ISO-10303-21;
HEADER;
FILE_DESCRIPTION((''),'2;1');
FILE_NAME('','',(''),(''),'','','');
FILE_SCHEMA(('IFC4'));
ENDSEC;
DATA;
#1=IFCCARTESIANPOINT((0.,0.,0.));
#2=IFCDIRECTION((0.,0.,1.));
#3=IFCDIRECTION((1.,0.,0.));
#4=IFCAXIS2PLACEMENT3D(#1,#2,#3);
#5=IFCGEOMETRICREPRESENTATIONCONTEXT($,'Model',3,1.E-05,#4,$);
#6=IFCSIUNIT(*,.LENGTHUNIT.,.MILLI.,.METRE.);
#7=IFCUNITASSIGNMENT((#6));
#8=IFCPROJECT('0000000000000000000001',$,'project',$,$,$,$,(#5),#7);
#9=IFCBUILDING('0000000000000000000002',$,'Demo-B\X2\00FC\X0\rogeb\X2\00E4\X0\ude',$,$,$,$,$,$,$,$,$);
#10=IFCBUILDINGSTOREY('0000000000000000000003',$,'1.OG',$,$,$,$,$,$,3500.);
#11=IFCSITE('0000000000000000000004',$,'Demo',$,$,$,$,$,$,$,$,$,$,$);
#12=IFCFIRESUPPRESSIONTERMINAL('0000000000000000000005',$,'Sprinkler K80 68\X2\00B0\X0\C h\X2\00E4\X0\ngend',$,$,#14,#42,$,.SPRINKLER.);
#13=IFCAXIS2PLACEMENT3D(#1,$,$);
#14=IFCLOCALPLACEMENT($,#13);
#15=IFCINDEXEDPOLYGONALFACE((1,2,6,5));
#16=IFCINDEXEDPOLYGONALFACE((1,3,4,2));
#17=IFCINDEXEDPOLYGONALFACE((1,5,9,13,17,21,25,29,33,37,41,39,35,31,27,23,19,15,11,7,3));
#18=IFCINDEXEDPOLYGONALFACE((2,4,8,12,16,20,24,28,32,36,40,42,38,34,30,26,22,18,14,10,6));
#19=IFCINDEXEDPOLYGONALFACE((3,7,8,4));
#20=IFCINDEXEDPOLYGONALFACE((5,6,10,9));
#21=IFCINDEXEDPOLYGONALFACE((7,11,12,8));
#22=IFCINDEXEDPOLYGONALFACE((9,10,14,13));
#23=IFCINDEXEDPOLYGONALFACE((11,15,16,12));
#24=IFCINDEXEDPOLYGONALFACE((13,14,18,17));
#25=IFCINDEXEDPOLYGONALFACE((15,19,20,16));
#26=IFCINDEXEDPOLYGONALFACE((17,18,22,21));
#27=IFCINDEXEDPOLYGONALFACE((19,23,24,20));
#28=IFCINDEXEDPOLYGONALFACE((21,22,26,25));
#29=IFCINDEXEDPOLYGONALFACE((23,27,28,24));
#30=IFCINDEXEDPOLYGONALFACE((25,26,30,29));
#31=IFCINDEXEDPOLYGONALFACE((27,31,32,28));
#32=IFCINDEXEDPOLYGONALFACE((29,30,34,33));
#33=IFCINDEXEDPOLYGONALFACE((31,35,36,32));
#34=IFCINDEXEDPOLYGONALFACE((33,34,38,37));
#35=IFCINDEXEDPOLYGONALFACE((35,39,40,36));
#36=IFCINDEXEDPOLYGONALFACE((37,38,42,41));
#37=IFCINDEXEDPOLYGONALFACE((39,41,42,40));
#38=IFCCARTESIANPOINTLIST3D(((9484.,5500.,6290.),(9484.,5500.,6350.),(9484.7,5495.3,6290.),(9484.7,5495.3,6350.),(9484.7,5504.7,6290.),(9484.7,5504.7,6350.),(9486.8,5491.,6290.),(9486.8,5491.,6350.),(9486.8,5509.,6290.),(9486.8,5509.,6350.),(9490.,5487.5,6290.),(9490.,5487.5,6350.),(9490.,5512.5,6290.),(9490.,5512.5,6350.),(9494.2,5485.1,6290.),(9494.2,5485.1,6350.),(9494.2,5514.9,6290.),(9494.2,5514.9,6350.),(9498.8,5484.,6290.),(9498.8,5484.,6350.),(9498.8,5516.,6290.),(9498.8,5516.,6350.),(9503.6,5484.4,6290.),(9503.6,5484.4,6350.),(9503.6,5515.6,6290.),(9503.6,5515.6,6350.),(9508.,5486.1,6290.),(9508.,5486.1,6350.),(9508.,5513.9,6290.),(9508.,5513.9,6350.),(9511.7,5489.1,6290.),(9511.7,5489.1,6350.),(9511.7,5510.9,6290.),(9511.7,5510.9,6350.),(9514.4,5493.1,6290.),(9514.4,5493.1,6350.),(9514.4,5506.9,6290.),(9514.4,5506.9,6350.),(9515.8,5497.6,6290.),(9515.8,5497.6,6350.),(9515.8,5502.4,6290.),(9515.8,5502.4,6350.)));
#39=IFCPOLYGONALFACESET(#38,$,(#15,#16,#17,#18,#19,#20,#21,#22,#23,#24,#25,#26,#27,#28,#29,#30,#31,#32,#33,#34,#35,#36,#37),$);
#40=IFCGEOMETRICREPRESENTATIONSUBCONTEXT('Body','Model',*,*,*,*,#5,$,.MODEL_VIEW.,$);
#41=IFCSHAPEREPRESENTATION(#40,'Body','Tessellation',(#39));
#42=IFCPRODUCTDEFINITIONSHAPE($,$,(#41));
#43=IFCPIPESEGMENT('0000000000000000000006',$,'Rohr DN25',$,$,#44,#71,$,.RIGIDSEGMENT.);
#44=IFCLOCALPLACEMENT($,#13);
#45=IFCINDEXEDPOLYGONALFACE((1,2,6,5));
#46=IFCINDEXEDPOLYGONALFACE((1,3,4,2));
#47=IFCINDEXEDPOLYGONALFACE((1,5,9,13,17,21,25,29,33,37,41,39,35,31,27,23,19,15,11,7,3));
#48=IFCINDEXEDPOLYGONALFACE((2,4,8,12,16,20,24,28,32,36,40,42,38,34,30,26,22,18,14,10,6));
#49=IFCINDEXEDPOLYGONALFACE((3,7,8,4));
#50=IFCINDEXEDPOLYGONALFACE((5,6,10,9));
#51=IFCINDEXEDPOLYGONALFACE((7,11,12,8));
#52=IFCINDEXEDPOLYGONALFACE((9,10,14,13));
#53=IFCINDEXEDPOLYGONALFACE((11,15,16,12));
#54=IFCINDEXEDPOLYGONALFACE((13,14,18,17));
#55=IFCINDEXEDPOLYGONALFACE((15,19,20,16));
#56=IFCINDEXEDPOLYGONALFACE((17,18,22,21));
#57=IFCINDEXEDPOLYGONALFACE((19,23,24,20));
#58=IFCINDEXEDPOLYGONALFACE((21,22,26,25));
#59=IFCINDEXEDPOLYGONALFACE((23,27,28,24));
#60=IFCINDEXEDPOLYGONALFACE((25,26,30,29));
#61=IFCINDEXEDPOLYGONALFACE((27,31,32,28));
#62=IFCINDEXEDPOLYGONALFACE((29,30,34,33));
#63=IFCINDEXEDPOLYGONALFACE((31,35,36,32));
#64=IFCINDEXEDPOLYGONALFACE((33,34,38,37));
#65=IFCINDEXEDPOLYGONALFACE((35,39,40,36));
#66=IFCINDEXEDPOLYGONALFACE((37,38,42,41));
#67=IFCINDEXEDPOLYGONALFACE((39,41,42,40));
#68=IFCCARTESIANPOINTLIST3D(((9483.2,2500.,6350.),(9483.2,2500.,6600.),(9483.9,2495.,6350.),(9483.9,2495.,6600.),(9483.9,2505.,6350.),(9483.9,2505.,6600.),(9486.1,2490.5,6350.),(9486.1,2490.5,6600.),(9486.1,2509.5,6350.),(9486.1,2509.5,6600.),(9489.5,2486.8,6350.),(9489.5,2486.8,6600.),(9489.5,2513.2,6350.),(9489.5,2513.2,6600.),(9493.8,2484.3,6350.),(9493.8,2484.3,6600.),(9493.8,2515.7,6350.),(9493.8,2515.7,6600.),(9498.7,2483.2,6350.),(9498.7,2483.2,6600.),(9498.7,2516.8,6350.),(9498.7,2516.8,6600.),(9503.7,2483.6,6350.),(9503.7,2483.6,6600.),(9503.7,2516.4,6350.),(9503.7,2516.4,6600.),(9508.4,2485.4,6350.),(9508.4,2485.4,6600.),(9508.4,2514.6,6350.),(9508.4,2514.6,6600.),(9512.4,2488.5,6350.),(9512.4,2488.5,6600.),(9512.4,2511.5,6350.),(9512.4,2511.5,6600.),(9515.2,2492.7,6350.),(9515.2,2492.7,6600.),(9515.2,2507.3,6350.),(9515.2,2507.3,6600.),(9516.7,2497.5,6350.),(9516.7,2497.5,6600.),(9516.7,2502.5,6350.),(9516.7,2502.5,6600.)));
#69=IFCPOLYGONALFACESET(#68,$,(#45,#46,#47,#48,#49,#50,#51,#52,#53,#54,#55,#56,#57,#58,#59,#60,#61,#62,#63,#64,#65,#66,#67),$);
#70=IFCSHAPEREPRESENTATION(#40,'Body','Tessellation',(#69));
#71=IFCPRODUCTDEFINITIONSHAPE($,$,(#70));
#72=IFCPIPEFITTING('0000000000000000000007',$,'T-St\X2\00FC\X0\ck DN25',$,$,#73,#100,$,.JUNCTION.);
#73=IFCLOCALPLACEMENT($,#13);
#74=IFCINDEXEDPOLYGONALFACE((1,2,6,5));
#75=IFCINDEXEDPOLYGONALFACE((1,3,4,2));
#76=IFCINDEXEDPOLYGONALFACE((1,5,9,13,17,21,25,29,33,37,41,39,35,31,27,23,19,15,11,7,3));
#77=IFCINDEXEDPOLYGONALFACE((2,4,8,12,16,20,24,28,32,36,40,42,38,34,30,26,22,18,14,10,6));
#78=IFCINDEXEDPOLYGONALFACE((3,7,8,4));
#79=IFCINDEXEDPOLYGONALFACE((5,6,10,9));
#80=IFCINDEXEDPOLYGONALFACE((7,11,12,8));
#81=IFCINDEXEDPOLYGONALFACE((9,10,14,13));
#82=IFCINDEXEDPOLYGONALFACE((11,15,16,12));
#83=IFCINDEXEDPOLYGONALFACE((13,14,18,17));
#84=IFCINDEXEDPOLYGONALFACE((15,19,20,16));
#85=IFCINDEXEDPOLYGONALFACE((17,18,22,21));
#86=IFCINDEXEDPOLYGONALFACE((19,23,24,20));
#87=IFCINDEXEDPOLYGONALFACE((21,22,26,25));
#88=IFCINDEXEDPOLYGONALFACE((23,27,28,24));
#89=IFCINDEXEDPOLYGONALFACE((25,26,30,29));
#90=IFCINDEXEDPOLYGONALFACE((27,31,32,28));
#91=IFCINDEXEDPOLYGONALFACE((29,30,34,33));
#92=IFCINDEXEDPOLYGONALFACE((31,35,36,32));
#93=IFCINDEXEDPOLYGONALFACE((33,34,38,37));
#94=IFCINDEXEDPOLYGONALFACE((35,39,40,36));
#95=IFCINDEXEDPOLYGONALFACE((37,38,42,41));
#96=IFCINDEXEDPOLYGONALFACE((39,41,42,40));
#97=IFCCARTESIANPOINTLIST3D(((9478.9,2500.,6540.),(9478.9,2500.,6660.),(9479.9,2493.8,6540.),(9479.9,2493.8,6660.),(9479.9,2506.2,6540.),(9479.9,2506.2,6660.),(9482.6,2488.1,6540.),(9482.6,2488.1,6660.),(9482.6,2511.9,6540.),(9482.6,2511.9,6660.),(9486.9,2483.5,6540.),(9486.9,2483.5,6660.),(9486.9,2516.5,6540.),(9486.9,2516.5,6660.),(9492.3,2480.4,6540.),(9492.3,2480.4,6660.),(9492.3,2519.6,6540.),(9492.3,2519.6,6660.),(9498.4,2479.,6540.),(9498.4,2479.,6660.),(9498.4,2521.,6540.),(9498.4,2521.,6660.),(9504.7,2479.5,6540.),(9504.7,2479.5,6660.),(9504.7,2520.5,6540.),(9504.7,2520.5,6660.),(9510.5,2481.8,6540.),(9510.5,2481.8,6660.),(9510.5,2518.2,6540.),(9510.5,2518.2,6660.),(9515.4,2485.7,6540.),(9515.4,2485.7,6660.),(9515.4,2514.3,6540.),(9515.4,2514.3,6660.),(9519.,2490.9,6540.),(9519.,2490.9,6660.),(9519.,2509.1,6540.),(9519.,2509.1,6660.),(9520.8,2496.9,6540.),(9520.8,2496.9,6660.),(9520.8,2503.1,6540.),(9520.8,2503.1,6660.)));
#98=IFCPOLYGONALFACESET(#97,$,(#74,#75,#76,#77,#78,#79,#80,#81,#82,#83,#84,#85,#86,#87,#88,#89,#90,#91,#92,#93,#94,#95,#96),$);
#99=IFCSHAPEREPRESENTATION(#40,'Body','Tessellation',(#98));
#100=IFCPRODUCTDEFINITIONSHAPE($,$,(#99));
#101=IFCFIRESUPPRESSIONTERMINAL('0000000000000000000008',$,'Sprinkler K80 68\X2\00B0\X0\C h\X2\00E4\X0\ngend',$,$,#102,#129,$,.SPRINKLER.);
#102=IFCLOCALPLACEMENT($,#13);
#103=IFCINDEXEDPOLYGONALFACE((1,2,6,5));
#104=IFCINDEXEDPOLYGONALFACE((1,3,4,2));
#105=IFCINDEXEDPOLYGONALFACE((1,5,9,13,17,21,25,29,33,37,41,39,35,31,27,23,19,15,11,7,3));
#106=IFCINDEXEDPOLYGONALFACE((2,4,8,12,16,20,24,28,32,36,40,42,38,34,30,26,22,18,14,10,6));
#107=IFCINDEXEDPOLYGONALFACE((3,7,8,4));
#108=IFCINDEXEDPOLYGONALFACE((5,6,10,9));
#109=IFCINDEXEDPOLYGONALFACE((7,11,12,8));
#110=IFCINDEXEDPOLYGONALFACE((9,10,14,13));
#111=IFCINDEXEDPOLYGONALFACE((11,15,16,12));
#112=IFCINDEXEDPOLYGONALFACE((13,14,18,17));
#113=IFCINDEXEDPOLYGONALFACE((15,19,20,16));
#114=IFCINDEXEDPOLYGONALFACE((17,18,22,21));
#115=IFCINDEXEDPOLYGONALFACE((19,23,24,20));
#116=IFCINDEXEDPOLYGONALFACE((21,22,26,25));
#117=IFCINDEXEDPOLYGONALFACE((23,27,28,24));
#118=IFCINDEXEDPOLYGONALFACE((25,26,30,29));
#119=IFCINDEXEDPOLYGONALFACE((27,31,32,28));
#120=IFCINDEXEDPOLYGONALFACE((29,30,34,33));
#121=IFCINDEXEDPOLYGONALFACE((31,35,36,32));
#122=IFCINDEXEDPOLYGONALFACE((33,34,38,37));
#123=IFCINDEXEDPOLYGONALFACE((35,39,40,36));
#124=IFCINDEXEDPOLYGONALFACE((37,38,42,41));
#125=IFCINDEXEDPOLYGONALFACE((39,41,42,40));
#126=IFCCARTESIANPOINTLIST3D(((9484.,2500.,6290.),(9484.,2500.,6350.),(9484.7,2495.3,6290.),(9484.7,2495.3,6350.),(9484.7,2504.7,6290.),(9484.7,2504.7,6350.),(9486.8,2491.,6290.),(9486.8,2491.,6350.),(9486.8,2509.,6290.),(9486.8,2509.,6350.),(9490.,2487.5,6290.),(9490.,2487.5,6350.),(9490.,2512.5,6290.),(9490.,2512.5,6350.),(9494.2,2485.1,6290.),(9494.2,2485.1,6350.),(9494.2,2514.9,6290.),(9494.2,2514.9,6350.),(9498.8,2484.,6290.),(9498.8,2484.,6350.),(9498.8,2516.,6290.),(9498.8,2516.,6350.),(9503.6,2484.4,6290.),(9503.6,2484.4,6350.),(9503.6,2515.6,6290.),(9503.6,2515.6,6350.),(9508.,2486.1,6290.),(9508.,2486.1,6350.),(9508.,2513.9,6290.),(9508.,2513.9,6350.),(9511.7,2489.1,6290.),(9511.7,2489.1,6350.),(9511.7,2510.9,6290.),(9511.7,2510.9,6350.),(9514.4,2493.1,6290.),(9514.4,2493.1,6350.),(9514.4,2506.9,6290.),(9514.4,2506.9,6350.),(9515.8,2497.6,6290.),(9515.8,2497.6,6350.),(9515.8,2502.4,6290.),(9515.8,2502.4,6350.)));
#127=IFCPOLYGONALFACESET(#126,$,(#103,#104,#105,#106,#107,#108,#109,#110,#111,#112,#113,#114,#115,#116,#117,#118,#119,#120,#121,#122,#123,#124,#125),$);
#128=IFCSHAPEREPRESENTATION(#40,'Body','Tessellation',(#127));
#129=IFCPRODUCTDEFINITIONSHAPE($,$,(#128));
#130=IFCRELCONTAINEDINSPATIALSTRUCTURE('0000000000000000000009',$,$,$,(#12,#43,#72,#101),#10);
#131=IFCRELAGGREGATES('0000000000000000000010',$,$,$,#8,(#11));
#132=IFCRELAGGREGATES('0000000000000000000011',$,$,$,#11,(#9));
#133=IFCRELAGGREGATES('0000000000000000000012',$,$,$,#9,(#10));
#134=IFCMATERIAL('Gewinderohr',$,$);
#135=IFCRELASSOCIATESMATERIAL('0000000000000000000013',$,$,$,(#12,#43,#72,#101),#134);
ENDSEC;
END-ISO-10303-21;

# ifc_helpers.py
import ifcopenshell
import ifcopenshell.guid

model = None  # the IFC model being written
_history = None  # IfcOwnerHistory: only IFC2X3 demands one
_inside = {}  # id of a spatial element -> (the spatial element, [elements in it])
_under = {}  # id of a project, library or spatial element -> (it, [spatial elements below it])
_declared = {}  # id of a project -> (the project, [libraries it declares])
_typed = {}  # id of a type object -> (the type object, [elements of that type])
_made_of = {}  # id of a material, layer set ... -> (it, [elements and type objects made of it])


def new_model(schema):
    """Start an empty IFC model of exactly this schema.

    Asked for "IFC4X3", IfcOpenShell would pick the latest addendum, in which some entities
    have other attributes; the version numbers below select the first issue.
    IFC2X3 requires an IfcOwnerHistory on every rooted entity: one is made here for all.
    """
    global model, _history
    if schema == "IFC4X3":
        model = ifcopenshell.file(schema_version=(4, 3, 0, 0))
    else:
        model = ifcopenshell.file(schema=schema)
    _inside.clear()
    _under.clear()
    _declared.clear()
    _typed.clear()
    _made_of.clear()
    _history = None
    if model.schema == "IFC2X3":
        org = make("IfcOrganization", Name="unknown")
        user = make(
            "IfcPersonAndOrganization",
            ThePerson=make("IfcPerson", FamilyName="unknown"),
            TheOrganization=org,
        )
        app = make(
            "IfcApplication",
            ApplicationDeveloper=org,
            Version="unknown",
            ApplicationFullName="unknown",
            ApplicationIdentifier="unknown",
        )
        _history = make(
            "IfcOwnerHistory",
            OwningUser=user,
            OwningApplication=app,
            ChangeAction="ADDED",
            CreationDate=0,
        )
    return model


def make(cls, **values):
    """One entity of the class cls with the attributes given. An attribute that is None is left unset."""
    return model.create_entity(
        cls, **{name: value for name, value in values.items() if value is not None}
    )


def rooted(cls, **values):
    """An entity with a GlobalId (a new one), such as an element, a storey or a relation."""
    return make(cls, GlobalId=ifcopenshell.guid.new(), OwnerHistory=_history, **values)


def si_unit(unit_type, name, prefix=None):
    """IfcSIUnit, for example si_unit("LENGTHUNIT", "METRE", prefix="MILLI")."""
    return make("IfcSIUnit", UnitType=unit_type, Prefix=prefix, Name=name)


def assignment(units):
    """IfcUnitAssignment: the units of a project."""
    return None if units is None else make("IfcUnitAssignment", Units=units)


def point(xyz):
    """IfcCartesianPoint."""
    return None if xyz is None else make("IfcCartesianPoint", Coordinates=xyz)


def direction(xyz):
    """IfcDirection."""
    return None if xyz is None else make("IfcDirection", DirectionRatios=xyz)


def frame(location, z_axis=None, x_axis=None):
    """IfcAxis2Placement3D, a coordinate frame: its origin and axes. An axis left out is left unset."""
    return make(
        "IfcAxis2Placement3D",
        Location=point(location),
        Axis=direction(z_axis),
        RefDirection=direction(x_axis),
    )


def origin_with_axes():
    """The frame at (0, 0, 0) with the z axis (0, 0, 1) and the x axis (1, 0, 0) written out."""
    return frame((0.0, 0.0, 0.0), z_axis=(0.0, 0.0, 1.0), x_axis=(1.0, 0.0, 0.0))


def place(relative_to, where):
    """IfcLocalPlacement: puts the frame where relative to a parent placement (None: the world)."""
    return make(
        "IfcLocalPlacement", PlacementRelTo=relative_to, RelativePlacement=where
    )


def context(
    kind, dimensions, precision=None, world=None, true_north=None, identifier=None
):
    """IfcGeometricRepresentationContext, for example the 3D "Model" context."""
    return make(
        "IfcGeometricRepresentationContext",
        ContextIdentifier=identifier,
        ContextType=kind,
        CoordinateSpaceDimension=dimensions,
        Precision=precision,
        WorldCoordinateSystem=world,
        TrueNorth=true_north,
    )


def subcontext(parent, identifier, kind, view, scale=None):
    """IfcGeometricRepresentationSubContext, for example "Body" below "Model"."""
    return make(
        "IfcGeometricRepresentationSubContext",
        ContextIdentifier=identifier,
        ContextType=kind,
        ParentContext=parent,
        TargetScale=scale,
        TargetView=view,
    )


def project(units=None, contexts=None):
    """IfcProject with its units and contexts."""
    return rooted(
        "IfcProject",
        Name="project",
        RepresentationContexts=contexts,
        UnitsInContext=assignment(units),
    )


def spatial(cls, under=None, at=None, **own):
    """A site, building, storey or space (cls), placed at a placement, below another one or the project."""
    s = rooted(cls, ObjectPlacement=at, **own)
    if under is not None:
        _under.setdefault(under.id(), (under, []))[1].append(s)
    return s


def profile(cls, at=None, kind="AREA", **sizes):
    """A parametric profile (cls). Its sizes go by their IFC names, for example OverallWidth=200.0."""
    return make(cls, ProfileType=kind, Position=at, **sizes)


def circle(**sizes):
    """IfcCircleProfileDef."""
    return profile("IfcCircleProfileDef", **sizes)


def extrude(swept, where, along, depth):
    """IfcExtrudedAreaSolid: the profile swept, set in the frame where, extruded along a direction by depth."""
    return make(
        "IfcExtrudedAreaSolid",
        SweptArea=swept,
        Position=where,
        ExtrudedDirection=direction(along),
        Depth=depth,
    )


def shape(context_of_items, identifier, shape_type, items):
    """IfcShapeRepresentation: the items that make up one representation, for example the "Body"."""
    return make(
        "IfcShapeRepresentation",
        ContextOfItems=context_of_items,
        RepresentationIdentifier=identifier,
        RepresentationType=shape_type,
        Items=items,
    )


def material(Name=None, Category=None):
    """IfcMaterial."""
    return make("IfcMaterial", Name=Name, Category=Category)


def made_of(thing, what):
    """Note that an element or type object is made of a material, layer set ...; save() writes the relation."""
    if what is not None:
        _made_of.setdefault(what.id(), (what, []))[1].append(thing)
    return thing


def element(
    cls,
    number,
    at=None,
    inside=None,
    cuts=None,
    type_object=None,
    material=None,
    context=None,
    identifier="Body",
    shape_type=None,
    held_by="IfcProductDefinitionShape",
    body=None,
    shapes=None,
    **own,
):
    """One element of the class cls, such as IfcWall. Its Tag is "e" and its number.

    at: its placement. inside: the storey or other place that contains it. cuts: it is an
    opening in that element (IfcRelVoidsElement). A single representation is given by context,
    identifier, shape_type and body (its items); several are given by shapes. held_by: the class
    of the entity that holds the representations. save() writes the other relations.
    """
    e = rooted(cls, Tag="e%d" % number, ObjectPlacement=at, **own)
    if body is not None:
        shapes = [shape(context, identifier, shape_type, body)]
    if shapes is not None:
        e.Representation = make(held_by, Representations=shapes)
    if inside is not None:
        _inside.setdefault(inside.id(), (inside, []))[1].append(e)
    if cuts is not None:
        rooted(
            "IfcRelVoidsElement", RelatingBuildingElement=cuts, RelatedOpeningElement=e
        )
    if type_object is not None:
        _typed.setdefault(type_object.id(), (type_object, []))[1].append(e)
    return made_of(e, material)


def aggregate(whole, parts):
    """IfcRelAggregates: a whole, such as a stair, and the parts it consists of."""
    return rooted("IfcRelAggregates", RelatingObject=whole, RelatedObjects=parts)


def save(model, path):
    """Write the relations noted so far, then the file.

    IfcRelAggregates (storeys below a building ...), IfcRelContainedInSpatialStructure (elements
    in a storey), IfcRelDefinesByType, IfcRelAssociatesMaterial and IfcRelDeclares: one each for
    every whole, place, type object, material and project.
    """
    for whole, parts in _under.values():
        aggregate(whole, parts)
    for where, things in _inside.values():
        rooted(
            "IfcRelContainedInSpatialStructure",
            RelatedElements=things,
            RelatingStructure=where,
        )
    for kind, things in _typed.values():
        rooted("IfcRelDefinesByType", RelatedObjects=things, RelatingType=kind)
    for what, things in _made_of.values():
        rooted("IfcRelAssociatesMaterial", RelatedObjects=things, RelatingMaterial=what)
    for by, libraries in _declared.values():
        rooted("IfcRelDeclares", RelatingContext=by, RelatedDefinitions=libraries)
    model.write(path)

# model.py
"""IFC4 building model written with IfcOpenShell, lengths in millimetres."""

from ifc_helpers import new_model, si_unit, frame, origin_with_axes, place, context, subcontext, project, spatial, circle, extrude, material, element, save


model = new_model("IFC4")

# Units and contexts
model_context = context("Model", 3, precision=1e-05, world=origin_with_axes())
body_context = subcontext(model_context, "Body", "Model", "MODEL_VIEW")
ifc_project = project(units=[si_unit("LENGTHUNIT", "METRE", prefix="MILLI")], contexts=[model_context])

# Site, building, storey
site = spatial("IfcSite", under=ifc_project, Name="Demo")
building = spatial("IfcBuilding", under=site, Name="Demo-Bürogebäude")
storey = spatial("IfcBuildingStorey", under=building, Name="1.OG", Elevation=3500.0)

# Shared definitions
ifc_material_1 = material(Name="Gewinderohr")

# Fire suppression terminal
fire_suppression_terminal_1_placement = place(None, frame((9500.0, 5500.0, 6350.0), z_axis=(0.0, 0.0, -1.0), x_axis=(-1.0, 0.0, 0.0)))
element("IfcFireSuppressionTerminal", 1, at=fire_suppression_terminal_1_placement, inside=storey, material=ifc_material_1, Name="Sprinkler K80 68°C hängend", PredefinedType="SPRINKLER", context=body_context, shape_type="SweptSolid", body=[
    extrude(circle(Radius=16.0), origin_with_axes(), (0.0, 0.0, 1.0), 60.0),
])

# Pipe segment
pipe_segment_1_placement = place(None, frame((9500.0, 2500.0, 6600.0), z_axis=(0.0, 0.0, -1.0), x_axis=(-1.0, 0.0, 0.0)))
element("IfcPipeSegment", 2, at=pipe_segment_1_placement, inside=storey, material=ifc_material_1, Name="Rohr DN25", PredefinedType="RIGIDSEGMENT", context=body_context, shape_type="SweptSolid", body=[
    extrude(circle(Radius=16.9), origin_with_axes(), (0.0, 0.0, 1.0), 250.0),
])

# Pipe fitting
pipe_fitting_1_placement = place(None, frame((9500.0, 2500.0, 6660.0), z_axis=(0.0, 0.0, -1.0), x_axis=(-1.0, 0.0, 0.0)))
element("IfcPipeFitting", 3, at=pipe_fitting_1_placement, inside=storey, material=ifc_material_1, Name="T-Stück DN25", PredefinedType="JUNCTION", context=body_context, shape_type="SweptSolid", body=[
    extrude(circle(Radius=21.1), origin_with_axes(), (0.0, 0.0, 1.0), 120.0),
])

# Fire suppression terminal
fire_suppression_terminal_2_placement = place(None, frame((9500.0, 2500.0, 6350.0), z_axis=(0.0, 0.0, -1.0), x_axis=(-1.0, 0.0, 0.0)))
element("IfcFireSuppressionTerminal", 4, at=fire_suppression_terminal_2_placement, inside=storey, material=ifc_material_1, Name="Sprinkler K80 68°C hängend", PredefinedType="SPRINKLER", context=body_context, shape_type="SweptSolid", body=[
    extrude(circle(Radius=16.0), origin_with_axes(), (0.0, 0.0, 1.0), 60.0),
])

save(model, "model.ifc")
